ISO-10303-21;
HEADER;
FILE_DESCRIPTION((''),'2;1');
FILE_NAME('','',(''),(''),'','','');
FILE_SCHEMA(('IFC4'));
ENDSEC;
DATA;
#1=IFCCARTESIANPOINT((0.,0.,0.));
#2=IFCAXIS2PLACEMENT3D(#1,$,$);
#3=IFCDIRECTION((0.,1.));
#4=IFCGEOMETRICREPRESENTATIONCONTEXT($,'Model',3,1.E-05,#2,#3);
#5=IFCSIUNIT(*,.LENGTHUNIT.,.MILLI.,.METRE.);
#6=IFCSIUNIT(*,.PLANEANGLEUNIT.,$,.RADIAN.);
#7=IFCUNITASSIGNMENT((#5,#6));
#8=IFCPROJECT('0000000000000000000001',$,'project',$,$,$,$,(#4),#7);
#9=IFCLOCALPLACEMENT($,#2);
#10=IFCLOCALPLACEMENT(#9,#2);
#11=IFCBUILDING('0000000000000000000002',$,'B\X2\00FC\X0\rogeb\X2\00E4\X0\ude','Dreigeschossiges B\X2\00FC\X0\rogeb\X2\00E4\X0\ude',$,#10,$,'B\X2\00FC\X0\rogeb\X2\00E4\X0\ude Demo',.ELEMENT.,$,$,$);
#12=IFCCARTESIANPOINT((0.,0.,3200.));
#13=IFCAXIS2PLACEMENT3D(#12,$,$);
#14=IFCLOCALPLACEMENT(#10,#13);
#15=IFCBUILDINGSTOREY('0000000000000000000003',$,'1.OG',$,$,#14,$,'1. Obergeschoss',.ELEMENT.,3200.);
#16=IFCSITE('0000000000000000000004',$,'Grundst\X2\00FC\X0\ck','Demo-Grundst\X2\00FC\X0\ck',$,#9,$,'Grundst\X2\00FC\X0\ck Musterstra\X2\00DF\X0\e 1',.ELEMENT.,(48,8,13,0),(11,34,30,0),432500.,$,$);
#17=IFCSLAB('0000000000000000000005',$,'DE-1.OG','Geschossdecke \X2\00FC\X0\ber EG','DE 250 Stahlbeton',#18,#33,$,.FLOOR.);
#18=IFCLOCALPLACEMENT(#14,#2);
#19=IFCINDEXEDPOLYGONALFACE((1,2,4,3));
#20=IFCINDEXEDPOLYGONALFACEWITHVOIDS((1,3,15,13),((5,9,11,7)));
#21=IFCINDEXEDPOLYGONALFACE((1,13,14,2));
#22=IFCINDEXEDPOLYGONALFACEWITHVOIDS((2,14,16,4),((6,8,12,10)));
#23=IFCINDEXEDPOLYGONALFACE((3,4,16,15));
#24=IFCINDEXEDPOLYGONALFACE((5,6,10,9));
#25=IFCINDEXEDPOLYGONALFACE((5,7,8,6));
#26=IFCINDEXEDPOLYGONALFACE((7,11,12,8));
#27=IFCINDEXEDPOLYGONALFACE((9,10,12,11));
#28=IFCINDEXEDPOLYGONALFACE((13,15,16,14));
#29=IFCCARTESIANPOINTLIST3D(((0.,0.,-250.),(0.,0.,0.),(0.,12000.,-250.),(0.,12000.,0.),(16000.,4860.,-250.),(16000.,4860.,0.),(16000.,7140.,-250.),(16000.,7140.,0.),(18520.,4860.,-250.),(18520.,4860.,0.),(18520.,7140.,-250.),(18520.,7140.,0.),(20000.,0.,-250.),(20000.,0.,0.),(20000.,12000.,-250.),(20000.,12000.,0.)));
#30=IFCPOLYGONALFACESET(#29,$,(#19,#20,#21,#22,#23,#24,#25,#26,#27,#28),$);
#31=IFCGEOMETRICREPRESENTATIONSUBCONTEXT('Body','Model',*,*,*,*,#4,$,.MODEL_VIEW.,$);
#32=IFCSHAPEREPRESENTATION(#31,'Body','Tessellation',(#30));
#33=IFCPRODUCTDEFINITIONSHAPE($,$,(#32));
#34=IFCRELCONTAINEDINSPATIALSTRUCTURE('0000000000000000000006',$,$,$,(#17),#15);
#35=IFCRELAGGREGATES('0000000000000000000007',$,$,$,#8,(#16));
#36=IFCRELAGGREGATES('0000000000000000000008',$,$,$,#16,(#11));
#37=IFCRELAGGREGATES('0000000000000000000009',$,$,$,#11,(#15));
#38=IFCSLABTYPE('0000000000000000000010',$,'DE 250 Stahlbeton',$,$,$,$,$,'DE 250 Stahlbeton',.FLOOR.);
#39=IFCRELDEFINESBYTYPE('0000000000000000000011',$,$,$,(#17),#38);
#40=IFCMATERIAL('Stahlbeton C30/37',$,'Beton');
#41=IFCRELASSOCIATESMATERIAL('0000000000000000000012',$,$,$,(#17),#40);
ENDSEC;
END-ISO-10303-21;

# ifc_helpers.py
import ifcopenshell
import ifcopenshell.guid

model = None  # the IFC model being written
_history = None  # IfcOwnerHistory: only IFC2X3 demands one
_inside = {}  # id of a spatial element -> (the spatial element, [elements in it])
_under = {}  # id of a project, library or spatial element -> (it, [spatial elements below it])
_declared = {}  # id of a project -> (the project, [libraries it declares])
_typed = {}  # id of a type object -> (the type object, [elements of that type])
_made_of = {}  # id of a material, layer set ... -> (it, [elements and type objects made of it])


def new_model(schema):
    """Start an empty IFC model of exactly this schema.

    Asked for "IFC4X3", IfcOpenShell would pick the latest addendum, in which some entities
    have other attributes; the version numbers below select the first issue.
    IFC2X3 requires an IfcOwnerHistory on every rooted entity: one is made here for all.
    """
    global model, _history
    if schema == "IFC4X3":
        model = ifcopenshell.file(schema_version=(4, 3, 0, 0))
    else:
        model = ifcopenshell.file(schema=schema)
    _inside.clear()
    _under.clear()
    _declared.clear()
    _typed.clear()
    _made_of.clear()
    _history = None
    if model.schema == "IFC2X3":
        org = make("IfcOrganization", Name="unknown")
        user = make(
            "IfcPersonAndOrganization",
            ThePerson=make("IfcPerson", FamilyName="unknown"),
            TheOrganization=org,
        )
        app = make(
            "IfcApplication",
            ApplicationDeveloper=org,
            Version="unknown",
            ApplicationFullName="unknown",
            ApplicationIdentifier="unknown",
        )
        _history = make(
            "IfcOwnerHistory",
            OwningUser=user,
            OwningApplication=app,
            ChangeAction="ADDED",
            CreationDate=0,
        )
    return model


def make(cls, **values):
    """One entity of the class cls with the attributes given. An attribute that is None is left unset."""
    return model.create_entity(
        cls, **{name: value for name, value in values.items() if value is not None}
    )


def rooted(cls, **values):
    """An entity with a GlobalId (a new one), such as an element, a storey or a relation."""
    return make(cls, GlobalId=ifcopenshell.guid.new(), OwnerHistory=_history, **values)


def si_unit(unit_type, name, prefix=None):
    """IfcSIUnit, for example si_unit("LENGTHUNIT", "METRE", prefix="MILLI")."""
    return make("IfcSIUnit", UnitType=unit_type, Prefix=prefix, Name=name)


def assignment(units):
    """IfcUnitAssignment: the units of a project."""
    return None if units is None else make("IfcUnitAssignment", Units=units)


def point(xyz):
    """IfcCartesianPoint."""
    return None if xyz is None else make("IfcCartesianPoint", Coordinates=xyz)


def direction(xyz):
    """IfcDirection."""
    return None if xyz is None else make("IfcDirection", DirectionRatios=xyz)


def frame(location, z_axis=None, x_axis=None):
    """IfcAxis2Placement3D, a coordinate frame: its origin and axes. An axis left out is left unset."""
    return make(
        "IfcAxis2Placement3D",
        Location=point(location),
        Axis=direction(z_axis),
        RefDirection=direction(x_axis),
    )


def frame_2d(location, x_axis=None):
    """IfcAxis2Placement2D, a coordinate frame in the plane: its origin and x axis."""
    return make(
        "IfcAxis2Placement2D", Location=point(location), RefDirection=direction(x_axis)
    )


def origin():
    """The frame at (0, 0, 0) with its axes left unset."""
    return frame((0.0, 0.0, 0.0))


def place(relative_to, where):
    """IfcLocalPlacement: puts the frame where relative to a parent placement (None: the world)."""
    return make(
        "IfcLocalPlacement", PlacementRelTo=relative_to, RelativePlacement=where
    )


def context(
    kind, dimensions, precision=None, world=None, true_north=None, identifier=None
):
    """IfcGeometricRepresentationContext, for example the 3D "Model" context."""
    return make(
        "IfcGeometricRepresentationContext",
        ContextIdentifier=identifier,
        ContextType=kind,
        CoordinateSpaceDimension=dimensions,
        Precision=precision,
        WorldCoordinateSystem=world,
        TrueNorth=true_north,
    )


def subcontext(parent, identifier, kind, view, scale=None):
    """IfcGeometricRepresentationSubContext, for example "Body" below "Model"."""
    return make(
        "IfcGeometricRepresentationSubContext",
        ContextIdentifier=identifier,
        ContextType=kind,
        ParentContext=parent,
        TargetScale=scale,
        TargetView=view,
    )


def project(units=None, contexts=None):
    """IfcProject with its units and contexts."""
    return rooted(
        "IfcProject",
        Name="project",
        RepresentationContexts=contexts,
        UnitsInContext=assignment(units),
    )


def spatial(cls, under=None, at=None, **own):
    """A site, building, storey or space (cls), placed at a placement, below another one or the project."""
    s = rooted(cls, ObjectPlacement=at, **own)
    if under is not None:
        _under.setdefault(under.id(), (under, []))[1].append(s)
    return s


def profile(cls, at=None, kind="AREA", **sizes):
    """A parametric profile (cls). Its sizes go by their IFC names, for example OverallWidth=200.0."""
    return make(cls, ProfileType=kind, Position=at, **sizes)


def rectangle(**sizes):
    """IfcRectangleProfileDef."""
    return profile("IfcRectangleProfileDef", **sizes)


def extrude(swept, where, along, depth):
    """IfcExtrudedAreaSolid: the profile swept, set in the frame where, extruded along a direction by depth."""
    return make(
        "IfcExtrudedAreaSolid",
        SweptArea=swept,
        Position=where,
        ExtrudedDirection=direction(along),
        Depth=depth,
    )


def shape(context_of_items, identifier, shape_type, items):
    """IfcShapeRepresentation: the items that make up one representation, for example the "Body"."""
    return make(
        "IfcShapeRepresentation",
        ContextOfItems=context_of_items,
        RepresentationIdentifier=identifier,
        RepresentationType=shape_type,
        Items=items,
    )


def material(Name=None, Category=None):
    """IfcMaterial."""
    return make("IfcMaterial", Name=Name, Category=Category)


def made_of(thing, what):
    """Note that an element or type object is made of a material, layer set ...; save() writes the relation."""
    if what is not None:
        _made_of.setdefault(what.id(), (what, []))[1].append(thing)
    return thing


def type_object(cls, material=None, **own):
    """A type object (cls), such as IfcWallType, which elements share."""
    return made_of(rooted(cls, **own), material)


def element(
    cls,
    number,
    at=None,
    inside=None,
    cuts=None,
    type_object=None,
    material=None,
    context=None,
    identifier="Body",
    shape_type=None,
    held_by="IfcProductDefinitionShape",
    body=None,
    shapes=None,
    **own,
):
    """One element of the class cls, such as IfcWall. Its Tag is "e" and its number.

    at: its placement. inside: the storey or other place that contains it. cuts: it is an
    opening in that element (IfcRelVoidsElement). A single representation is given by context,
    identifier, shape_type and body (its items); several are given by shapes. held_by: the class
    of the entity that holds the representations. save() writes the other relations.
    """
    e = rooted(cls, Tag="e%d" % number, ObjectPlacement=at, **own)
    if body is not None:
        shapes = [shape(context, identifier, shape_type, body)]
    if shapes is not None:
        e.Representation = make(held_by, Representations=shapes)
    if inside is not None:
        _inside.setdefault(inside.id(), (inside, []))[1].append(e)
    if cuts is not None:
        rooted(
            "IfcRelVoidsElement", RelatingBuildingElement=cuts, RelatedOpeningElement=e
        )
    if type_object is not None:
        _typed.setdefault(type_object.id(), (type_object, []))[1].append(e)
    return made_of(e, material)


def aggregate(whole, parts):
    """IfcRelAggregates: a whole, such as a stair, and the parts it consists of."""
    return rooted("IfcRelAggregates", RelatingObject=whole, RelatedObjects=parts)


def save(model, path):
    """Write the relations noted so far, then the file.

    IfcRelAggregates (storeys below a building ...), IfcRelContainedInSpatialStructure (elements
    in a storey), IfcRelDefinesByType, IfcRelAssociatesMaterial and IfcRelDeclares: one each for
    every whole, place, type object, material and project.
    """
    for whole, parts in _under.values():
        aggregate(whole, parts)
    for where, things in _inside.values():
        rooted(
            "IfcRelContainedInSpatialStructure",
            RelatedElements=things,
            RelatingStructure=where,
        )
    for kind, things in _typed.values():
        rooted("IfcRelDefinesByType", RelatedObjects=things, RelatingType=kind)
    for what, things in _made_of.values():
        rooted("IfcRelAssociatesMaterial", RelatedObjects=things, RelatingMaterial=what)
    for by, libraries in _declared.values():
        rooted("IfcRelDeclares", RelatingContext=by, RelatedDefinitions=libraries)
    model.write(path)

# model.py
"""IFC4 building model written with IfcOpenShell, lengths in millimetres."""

from ifc_helpers import new_model, si_unit, direction, frame, frame_2d, origin, place, context, subcontext, project, spatial, rectangle, extrude, material, type_object, element, save


model = new_model("IFC4")

# Units and contexts
model_context = context("Model", 3, precision=1e-05, world=origin(), true_north=direction((0.0, 1.0)))
body_context = subcontext(model_context, "Body", "Model", "MODEL_VIEW")
ifc_project = project(units=[si_unit("LENGTHUNIT", "METRE", prefix="MILLI"), si_unit("PLANEANGLEUNIT", "RADIAN")], contexts=[model_context])

# Site, building, storey
site_placement = place(None, origin())
site = spatial("IfcSite", under=ifc_project, at=site_placement, Name="Grundstück", Description="Demo-Grundstück", LongName="Grundstück Musterstraße 1", CompositionType="ELEMENT", RefLatitude=(48, 8, 13, 0), RefLongitude=(11, 34, 30, 0), RefElevation=432500.0)
building_placement = place(site_placement, origin())
building = spatial("IfcBuilding", under=site, at=building_placement, Name="Bürogebäude", Description="Dreigeschossiges Bürogebäude", LongName="Bürogebäude Demo", CompositionType="ELEMENT")
storey_placement = place(building_placement, frame((0.0, 0.0, 3200.0)))
storey = spatial("IfcBuildingStorey", under=building, at=storey_placement, Name="1.OG", LongName="1. Obergeschoss", CompositionType="ELEMENT", Elevation=3200.0)

# Slab, opening
ifc_material_1 = material(Name="Stahlbeton C30/37", Category="Beton")
slab_type = type_object("IfcSlabType", Name="DE 250 Stahlbeton", ElementType="DE 250 Stahlbeton", PredefinedType="FLOOR")
slab_placement = place(storey_placement, origin())
slab = element("IfcSlab", 1, at=slab_placement, inside=storey, type_object=slab_type, material=ifc_material_1, Name="DE-1.OG", Description="Geschossdecke über EG", ObjectType="DE 250 Stahlbeton", PredefinedType="FLOOR", context=body_context, shape_type="SweptSolid", body=[
    extrude(rectangle(XDim=20000.0, YDim=12000.0, at=frame_2d((10000.0, 6000.0))), frame((0.0, 0.0, -250.0)), (0.0, 0.0, 1.0), 250.0),
])
opening_1_placement = place(slab_placement, origin())
element("IfcOpeningElement", 2, at=opening_1_placement, cuts=slab, PredefinedType="OPENING", context=body_context, shape_type="SweptSolid", body=[
    extrude(rectangle(XDim=2520.0, YDim=2280.0, at=frame_2d((17260.0, 6000.0))), frame((0.0, 0.0, -270.0)), (0.0, 0.0, 1.0), 290.0),
])

save(model, "model.ifc")
